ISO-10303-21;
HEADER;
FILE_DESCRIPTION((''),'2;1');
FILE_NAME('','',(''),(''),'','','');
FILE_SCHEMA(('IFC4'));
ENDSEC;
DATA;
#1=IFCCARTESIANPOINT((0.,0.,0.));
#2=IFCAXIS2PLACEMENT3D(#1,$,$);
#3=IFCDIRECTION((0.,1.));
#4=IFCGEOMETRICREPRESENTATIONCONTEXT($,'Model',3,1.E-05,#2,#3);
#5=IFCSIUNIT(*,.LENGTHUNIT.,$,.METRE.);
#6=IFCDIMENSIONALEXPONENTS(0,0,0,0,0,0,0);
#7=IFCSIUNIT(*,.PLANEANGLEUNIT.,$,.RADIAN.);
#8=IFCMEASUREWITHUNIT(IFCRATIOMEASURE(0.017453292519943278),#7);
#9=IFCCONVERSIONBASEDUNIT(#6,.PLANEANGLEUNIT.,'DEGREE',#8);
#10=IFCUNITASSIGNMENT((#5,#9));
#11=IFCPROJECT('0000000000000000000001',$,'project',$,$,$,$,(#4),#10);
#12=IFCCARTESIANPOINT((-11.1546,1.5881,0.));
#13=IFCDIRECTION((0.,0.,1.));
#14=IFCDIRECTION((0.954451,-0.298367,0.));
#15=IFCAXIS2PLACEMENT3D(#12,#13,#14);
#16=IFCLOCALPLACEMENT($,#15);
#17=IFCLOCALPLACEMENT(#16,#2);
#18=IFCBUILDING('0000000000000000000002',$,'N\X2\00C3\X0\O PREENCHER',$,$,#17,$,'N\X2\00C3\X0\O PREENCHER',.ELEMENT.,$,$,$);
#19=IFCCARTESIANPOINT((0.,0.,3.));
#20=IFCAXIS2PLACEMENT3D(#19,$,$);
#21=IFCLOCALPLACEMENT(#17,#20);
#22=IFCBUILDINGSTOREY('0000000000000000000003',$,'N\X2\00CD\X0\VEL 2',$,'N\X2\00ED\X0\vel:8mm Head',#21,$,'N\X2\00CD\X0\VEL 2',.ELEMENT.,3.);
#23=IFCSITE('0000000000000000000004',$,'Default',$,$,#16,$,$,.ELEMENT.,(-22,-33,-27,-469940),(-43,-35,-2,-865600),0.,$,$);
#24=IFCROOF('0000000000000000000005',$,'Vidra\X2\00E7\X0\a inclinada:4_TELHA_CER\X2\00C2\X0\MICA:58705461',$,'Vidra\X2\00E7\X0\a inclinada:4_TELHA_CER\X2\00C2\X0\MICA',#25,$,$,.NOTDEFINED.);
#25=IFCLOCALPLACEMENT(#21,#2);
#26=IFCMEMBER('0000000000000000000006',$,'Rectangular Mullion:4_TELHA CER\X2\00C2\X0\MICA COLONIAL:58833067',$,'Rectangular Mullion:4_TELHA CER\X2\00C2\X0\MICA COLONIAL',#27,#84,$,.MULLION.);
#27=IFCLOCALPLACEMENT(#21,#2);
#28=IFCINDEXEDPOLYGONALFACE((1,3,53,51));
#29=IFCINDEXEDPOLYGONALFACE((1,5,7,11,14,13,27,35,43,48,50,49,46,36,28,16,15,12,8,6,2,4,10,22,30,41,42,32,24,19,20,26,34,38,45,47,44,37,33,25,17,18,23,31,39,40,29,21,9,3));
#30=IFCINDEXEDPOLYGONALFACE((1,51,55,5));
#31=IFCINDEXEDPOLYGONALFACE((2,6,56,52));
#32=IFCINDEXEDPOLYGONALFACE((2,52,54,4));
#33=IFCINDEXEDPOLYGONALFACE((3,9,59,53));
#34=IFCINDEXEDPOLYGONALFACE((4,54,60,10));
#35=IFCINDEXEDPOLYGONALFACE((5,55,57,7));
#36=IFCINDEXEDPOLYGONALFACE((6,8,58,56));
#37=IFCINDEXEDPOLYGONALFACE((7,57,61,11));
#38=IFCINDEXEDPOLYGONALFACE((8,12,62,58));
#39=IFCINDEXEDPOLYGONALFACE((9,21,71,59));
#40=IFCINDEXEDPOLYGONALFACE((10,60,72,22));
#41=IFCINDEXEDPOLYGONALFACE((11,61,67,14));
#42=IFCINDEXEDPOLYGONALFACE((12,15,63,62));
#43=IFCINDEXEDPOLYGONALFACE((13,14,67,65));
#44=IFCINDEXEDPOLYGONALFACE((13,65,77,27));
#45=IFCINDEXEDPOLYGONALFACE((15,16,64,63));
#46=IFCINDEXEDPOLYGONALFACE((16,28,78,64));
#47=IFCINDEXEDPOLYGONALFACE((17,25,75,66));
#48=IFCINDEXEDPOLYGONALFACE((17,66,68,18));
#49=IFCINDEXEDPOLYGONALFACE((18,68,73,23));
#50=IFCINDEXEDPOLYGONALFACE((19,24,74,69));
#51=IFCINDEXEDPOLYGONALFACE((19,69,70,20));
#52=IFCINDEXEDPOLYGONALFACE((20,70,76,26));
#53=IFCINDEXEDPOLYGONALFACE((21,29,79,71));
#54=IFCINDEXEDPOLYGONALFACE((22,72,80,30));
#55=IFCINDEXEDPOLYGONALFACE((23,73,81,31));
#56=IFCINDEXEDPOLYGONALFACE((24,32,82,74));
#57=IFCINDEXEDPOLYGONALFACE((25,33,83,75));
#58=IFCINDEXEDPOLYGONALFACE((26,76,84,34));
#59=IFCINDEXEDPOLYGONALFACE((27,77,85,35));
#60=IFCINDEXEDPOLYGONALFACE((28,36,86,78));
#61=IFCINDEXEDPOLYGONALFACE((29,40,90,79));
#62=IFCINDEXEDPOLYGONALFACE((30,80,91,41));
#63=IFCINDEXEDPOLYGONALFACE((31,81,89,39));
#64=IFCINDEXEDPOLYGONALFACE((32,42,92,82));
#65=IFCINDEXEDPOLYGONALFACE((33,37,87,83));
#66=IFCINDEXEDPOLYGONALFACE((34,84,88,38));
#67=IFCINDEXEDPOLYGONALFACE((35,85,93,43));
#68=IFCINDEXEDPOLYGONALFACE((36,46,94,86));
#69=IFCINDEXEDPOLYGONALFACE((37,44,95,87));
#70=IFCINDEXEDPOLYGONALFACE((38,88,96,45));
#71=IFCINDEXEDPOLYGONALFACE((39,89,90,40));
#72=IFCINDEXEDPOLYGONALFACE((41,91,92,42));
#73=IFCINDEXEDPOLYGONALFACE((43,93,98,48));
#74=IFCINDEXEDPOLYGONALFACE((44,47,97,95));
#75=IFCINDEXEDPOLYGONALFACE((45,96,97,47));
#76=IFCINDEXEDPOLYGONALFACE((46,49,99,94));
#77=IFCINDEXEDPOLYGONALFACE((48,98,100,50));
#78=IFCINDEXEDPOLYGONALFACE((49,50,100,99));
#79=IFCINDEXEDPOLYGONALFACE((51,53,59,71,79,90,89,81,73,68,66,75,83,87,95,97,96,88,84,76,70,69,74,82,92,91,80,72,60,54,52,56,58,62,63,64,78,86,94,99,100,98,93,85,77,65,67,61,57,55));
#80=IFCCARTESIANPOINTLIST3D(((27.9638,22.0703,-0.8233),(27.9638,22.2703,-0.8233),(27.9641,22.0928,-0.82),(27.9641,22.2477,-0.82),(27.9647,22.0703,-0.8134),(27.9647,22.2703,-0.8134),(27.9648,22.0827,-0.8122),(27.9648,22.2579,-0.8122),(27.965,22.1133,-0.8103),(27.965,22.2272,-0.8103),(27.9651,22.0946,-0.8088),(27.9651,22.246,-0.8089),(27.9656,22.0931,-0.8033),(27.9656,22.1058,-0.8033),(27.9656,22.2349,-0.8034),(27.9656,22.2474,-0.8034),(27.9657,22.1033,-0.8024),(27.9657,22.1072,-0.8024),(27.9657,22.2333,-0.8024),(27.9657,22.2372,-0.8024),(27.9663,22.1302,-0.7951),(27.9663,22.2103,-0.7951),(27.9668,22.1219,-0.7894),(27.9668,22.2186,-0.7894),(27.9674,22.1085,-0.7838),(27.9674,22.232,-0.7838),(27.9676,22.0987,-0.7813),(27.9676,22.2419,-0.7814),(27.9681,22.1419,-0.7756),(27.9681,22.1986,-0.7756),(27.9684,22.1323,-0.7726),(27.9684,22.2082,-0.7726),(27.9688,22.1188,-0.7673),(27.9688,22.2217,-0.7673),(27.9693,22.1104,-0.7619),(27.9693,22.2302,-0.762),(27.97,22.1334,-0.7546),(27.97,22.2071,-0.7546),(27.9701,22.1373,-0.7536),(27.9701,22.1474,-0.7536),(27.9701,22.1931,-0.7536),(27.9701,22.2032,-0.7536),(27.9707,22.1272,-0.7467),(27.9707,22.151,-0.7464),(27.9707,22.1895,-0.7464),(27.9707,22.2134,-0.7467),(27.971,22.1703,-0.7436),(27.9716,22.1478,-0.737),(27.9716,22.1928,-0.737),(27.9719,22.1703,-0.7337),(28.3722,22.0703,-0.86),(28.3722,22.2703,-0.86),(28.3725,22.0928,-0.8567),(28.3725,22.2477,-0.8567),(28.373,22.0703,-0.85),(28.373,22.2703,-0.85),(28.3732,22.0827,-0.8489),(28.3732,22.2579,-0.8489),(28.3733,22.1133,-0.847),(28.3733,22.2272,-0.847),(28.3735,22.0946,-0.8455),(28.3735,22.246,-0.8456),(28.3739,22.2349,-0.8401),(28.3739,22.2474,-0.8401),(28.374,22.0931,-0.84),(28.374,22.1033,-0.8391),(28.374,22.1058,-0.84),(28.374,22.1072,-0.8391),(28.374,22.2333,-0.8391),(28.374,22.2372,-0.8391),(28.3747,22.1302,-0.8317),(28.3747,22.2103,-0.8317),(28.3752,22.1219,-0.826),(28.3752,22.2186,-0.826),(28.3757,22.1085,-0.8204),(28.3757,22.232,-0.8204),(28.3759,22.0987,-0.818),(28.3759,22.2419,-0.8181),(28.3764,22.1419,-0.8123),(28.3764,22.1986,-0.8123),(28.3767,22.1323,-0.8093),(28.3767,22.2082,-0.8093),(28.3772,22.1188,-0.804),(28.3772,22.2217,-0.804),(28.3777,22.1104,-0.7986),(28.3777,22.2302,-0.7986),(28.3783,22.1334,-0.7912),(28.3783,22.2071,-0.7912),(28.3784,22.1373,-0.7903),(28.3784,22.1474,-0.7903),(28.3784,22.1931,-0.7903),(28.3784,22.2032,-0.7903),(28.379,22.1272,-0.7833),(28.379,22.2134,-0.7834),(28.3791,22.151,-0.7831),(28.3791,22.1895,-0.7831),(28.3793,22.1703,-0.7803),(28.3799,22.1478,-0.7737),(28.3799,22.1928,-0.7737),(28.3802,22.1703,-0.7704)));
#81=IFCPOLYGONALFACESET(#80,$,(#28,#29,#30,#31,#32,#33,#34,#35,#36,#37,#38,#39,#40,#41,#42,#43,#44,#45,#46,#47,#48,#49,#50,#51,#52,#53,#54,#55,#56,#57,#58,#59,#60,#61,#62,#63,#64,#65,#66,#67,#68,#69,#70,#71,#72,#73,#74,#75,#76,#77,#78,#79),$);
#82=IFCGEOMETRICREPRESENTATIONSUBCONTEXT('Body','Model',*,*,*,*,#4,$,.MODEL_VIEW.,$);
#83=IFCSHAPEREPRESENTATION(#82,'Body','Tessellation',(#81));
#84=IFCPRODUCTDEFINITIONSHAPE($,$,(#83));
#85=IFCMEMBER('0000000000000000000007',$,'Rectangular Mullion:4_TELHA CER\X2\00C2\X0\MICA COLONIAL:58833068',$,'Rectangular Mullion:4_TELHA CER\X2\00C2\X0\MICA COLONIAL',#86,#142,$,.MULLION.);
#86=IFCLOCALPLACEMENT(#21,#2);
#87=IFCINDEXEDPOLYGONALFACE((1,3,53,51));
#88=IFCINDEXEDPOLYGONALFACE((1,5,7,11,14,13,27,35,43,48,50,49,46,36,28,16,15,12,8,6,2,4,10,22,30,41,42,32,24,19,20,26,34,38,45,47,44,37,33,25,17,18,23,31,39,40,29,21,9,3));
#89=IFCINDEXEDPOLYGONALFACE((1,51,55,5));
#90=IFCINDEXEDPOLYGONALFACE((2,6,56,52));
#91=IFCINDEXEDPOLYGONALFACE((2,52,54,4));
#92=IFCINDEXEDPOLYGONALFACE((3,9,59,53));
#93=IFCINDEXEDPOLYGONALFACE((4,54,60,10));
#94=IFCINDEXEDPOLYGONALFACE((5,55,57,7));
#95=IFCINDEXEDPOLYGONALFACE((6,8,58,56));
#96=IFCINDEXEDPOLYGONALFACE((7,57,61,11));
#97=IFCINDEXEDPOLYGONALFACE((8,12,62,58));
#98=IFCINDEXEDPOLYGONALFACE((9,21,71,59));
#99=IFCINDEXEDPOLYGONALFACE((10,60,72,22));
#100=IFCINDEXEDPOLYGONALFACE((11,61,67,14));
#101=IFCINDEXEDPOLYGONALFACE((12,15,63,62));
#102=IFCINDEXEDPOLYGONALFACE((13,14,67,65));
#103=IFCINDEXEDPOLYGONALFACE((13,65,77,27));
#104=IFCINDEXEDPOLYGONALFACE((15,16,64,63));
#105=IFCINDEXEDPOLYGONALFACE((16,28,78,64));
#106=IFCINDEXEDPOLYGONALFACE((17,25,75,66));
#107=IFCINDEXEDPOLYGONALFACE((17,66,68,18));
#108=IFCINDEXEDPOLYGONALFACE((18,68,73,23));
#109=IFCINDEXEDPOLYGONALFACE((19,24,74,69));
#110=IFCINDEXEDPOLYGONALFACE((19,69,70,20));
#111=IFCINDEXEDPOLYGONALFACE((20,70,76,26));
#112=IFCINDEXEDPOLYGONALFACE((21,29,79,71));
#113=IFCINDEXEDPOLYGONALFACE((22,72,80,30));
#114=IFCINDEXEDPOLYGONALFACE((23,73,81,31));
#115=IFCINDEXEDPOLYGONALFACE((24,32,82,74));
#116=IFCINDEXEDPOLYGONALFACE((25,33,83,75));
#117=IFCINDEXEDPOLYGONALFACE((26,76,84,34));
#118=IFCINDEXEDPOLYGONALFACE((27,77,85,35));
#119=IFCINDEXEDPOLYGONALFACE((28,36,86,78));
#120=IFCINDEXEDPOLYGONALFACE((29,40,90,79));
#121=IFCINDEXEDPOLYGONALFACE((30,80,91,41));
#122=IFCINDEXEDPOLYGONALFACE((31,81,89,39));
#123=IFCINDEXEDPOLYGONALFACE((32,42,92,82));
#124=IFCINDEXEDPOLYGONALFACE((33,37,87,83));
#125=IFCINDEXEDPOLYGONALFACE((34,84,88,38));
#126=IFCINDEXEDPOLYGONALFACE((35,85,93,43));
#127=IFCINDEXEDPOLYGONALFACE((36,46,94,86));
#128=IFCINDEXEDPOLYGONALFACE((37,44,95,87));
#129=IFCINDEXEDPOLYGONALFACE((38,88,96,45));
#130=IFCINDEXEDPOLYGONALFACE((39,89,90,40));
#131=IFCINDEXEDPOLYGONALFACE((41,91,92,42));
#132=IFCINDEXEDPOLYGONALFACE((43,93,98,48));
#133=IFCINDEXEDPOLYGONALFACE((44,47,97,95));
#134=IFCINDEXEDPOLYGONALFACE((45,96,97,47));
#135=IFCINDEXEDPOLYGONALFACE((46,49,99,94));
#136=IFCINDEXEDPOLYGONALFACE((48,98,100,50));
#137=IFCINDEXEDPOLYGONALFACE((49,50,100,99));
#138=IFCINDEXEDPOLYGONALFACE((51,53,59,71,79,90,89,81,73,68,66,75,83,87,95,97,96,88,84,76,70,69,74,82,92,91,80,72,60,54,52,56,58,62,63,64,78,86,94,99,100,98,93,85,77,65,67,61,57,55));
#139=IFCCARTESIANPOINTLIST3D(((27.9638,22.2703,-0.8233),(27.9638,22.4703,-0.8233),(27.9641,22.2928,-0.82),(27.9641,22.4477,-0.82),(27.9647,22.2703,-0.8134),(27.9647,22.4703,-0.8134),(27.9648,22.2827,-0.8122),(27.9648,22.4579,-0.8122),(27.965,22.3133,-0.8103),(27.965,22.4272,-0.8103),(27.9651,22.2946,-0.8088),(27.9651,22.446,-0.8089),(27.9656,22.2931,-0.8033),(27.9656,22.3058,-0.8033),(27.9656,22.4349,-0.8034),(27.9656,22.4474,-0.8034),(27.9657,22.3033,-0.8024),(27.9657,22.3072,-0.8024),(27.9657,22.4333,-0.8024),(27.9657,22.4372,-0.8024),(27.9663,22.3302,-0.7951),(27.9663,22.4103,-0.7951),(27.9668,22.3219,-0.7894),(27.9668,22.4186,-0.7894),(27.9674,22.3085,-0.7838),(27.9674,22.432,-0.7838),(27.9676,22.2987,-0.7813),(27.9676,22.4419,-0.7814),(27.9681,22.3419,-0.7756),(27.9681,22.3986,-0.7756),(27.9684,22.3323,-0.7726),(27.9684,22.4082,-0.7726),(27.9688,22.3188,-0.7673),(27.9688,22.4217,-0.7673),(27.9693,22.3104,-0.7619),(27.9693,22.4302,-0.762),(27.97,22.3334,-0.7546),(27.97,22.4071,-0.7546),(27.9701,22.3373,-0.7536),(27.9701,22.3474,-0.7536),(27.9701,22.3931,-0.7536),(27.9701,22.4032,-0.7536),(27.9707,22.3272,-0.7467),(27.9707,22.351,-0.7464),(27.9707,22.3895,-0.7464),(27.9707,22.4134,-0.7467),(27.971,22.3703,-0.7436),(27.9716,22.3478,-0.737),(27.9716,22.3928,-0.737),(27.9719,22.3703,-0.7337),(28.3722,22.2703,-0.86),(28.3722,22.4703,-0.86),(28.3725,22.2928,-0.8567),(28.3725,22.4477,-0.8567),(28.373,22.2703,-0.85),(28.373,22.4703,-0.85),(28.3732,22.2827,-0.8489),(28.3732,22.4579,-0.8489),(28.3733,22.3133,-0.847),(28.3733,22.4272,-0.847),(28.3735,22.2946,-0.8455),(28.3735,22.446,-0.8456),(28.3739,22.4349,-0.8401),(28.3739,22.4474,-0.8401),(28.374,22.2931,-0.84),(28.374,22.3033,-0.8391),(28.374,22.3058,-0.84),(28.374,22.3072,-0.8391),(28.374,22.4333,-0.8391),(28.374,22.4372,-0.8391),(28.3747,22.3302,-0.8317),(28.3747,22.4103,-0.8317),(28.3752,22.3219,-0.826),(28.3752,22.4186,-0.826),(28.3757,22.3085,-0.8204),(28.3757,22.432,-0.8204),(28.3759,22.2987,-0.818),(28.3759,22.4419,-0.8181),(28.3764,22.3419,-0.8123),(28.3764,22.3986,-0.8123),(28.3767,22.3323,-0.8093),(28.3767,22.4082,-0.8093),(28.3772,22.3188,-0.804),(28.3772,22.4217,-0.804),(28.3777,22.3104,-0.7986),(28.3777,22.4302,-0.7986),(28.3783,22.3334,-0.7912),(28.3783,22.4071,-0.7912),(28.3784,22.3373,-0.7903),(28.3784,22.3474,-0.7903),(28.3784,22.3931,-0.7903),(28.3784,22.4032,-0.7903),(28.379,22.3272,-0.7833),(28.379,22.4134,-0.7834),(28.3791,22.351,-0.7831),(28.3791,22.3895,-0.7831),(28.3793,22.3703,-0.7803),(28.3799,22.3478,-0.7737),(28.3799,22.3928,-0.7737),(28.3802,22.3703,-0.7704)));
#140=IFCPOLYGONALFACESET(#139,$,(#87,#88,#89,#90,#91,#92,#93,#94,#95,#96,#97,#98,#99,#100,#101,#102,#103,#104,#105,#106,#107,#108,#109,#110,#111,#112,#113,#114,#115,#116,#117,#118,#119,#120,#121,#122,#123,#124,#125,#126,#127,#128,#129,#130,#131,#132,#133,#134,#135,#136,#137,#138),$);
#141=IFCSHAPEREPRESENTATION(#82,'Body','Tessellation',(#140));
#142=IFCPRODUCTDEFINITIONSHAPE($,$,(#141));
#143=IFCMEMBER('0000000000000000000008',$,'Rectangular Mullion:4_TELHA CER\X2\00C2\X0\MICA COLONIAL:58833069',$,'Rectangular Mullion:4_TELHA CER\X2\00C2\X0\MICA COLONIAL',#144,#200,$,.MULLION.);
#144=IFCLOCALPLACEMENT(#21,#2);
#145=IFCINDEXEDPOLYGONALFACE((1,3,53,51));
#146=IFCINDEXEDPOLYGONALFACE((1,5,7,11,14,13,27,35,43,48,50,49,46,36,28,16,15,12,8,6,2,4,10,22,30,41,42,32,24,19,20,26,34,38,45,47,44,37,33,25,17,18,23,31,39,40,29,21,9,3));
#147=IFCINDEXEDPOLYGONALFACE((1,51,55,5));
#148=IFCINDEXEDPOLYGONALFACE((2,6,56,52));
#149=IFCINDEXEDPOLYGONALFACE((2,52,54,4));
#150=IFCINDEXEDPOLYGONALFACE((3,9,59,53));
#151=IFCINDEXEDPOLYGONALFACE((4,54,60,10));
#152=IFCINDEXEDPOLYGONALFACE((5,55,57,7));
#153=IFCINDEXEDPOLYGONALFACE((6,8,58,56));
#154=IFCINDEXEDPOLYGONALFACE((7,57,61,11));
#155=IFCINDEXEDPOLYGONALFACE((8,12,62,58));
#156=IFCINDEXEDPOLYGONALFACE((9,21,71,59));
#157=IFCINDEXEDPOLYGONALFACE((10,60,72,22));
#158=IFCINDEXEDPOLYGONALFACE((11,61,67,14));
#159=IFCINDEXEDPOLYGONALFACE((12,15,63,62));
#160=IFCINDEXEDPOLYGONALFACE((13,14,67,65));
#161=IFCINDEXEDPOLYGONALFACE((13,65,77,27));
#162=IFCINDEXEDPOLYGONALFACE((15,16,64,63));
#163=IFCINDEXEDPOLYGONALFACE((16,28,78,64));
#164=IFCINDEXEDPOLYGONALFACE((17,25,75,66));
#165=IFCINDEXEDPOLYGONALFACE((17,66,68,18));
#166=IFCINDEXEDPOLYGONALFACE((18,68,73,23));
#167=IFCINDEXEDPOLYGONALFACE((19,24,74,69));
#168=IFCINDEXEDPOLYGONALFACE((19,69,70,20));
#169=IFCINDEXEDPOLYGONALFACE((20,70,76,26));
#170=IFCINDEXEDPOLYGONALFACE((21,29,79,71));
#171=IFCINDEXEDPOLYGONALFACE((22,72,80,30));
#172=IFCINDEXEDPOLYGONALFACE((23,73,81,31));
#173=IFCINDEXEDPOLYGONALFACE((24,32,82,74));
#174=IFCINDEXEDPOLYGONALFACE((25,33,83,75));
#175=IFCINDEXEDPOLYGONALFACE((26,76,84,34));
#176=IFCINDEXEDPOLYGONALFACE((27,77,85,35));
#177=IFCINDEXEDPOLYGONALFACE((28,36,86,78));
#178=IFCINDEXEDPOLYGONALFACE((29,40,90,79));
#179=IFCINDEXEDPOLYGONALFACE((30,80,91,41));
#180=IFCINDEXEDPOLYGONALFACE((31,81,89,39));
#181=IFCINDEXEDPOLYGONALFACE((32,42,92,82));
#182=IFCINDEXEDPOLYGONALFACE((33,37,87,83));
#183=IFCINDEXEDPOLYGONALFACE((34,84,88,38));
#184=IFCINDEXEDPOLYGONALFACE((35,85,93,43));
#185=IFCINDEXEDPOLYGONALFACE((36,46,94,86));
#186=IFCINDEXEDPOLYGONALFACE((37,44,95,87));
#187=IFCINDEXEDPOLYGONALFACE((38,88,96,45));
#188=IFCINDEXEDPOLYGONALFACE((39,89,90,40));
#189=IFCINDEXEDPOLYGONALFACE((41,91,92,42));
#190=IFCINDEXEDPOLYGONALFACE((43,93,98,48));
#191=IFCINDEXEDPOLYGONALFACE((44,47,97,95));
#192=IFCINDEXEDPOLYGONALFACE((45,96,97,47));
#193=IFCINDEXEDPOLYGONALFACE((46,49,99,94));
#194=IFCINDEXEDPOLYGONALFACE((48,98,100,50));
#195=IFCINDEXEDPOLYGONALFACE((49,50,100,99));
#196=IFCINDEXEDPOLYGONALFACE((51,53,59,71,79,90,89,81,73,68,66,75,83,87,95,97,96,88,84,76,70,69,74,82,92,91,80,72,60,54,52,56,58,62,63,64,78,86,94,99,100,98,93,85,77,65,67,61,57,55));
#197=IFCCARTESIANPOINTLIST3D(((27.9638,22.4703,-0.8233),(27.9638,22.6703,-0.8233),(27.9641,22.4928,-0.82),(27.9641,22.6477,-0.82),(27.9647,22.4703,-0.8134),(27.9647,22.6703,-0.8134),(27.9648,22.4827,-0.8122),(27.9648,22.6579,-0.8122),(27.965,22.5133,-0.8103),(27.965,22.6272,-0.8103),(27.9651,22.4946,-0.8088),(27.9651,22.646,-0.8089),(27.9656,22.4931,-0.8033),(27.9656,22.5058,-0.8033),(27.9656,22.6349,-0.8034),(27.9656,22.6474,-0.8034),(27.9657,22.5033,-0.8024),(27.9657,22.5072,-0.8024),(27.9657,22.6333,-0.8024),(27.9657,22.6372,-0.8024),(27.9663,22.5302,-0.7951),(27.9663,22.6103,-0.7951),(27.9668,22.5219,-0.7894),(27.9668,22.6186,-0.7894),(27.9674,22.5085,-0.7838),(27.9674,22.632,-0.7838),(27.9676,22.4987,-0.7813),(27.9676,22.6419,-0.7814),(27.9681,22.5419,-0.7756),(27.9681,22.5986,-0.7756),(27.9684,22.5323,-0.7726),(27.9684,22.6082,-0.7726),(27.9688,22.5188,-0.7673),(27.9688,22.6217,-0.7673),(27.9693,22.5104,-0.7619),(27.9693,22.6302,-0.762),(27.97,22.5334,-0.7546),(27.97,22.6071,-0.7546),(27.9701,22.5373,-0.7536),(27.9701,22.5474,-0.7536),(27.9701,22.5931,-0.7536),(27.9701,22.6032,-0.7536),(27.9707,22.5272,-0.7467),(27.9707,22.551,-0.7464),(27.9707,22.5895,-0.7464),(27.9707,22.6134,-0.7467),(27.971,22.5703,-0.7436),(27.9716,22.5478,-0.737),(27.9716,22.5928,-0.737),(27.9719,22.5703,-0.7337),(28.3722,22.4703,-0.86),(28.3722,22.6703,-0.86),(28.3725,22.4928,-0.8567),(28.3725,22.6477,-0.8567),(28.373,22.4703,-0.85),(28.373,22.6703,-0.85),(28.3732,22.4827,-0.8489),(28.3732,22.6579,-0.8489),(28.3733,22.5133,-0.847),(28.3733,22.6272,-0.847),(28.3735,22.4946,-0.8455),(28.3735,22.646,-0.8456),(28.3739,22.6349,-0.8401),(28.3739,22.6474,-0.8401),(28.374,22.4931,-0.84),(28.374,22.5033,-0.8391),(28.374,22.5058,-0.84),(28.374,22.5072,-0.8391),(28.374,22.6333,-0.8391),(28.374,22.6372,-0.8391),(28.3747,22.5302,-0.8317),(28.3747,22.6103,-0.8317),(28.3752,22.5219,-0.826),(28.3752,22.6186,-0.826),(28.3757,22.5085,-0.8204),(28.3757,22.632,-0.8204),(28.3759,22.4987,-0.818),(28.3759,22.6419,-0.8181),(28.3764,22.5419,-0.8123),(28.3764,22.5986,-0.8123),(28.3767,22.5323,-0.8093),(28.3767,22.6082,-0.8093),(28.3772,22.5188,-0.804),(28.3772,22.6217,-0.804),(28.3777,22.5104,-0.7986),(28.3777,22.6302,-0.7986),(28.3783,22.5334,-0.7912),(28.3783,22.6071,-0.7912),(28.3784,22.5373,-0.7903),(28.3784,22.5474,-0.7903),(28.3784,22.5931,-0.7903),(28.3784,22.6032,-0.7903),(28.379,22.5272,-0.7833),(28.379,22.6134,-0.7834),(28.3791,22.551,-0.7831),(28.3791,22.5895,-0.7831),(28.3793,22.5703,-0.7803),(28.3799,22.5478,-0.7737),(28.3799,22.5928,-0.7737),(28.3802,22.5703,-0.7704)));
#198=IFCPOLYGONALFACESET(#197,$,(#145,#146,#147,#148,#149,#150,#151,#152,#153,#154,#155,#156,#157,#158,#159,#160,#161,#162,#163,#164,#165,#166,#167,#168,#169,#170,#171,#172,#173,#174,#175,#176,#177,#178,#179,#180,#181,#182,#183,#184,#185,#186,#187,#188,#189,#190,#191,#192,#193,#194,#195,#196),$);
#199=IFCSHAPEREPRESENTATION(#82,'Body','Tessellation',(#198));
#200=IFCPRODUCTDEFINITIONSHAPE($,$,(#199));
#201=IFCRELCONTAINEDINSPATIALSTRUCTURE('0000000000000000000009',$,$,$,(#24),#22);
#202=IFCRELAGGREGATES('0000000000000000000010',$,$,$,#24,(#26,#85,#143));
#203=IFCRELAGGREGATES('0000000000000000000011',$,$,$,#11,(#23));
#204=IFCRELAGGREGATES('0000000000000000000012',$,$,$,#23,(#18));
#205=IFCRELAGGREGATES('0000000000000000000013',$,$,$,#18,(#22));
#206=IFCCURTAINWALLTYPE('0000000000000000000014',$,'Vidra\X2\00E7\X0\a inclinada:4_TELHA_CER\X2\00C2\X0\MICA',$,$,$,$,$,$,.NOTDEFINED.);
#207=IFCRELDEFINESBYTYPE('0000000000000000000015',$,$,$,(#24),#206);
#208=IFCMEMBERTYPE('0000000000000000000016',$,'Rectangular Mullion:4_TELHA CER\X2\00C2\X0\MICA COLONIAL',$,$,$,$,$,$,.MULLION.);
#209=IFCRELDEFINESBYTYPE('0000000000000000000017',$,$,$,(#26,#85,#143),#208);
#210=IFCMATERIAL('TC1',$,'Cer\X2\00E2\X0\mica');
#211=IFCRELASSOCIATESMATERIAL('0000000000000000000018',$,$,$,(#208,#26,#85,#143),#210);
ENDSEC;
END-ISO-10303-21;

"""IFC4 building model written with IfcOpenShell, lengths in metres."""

from ifc_helpers import new_model, entity, si_unit, converted_unit, direction, frame, origin, place, context, subcontext, project, spatial, line, arc, indexed_curve, outline, extrude, source, transform, mapped, material, type_object, type_shapes, element, aggregate, save


model = new_model("IFC4")

# Units and contexts
model_context = context("Model", 3, precision=1e-05, world=origin(), true_north=direction((0.0, 1.0)))
body_context = subcontext(model_context, "Body", "Model", "MODEL_VIEW")
ifc_project = project(units=[si_unit("LENGTHUNIT", "METRE"), converted_unit("PLANEANGLEUNIT", "DEGREE", entity("IfcRatioMeasure", 0.017453292519943278), si_unit("PLANEANGLEUNIT", "RADIAN"), dimensions=[0, 0, 0, 0, 0, 0, 0])], contexts=[model_context])

# Site, building, storey
site_placement = place(None, frame((-11.1546, 1.5881, 0.0), z_axis=(0.0, 0.0, 1.0), x_axis=(0.954451, -0.298367, 0.0)))
site = spatial("IfcSite", under=ifc_project, at=site_placement, Name="Default", CompositionType="ELEMENT", RefLatitude=(-22, -33, -27, -469940), RefLongitude=(-43, -35, -2, -865600), RefElevation=0.0)
building_placement = place(site_placement, origin())
building = spatial("IfcBuilding", under=site, at=building_placement, Name="NÃO PREENCHER", LongName="NÃO PREENCHER", CompositionType="ELEMENT")
storey_placement = place(building_placement, frame((0.0, 0.0, 3.0)))
storey = spatial("IfcBuildingStorey", under=building, at=storey_placement, Name="NÍVEL 2", ObjectType="Nível:8mm Head", LongName="NÍVEL 2", CompositionType="ELEMENT", Elevation=3.0)

# Roof, members
curtain_wall_type = type_object("IfcCurtainWallType", Name="Vidraça inclinada:4_TELHA_CERÂMICA", PredefinedType="NOTDEFINED")
roof_placement = place(storey_placement, frame((0.0, 0.0, -3.0)))
roof = element("IfcRoof", 1, at=roof_placement, inside=storey, type_object=curtain_wall_type, Name="Vidraça inclinada:4_TELHA_CERÂMICA:58705461", ObjectType="Vidraça inclinada:4_TELHA_CERÂMICA", PredefinedType="NOTDEFINED")
ifc_material = material(Name="TC1", Category="Cerâmica")
member_type_1 = type_object("IfcMemberType", Name="Rectangular Mullion:4_TELHA CERÂMICA COLONIAL", PredefinedType="MULLION", material=ifc_material)
shared_shape_1 = source(origin(), body_context, "Body", "SweptSolid", [
    extrude(outline(indexed_curve([(-0.029, -0.1), (-0.019, -0.1), (-0.0164, -0.0815), (-0.0089, -0.0645), (-0.0089, -0.0771), (0.061, 0.0), (-0.009, 0.0771), (-0.009, 0.0646), (-0.0165, 0.0816), (-0.019, 0.1), (-0.029, 0.1), (-0.0089, 0.0479), (0.041, 0.0229), (0.041, 0.0329), (0.0131, 0.0425), (-0.008, 0.0631), (-0.008, 0.067), (0.051, 0.0), (-0.008, -0.067), (-0.008, -0.0631), (0.0131, -0.0425), (0.041, -0.0329), (0.041, -0.0229), (-0.0089, -0.0479)], segments=[line(1, 2), arc(2, 3, 4), line(4, 5), arc(5, 6, 7), line(7, 8), arc(8, 9, 10), line(10, 11), arc(11, 12, 13), line(13, 14), arc(14, 15, 16), line(16, 17), arc(17, 18, 19), line(19, 20), arc(20, 21, 22), line(22, 23), arc(23, 24, 1)], self_intersect=False)), frame((0.0, -0.029, -0.41), z_axis=(0.0, 0.0, 1.0), x_axis=(0.0, -1.0, 0.0)), (0.0, 0.0, 1.0), 0.41),
])
type_shapes(member_type_1, [shared_shape_1])
member_1_placement = place(roof_placement, frame((27.9638, 22.1703, 2.1767), z_axis=(-0.99599, 0.0, 0.089469), x_axis=(0.0, 1.0, 0.0)))
member_1 = element("IfcMember", 2, at=member_1_placement, type_object=member_type_1, material=ifc_material, Name="Rectangular Mullion:4_TELHA CERÂMICA COLONIAL:58833067", ObjectType="Rectangular Mullion:4_TELHA CERÂMICA COLONIAL", PredefinedType="MULLION", context=body_context, shape_type="MappedRepresentation", body=[
    mapped(shared_shape_1, transform((0.0, 0.0, 0.0), scale=1.0)),
])
member_2_placement = place(roof_placement, frame((27.9638, 22.3703, 2.1767), z_axis=(-0.99599, 0.0, 0.089469), x_axis=(0.0, 1.0, 0.0)))
member_2 = element("IfcMember", 3, at=member_2_placement, type_object=member_type_1, material=ifc_material, Name="Rectangular Mullion:4_TELHA CERÂMICA COLONIAL:58833068", ObjectType="Rectangular Mullion:4_TELHA CERÂMICA COLONIAL", PredefinedType="MULLION", context=body_context, shape_type="MappedRepresentation", body=[
    mapped(shared_shape_1, transform((0.0, 0.0, 0.0), scale=1.0)),
])
member_3_placement = place(roof_placement, frame((27.9638, 22.5703, 2.1767), z_axis=(-0.99599, 0.0, 0.089469), x_axis=(0.0, 1.0, 0.0)))
member_3 = element("IfcMember", 4, at=member_3_placement, type_object=member_type_1, material=ifc_material, Name="Rectangular Mullion:4_TELHA CERÂMICA COLONIAL:58833069", ObjectType="Rectangular Mullion:4_TELHA CERÂMICA COLONIAL", PredefinedType="MULLION", context=body_context, shape_type="MappedRepresentation", body=[
    mapped(shared_shape_1, transform((0.0, 0.0, 0.0), scale=1.0)),
])
aggregate(roof, [member_1, member_2, member_3])

save(model, "model.ifc")
